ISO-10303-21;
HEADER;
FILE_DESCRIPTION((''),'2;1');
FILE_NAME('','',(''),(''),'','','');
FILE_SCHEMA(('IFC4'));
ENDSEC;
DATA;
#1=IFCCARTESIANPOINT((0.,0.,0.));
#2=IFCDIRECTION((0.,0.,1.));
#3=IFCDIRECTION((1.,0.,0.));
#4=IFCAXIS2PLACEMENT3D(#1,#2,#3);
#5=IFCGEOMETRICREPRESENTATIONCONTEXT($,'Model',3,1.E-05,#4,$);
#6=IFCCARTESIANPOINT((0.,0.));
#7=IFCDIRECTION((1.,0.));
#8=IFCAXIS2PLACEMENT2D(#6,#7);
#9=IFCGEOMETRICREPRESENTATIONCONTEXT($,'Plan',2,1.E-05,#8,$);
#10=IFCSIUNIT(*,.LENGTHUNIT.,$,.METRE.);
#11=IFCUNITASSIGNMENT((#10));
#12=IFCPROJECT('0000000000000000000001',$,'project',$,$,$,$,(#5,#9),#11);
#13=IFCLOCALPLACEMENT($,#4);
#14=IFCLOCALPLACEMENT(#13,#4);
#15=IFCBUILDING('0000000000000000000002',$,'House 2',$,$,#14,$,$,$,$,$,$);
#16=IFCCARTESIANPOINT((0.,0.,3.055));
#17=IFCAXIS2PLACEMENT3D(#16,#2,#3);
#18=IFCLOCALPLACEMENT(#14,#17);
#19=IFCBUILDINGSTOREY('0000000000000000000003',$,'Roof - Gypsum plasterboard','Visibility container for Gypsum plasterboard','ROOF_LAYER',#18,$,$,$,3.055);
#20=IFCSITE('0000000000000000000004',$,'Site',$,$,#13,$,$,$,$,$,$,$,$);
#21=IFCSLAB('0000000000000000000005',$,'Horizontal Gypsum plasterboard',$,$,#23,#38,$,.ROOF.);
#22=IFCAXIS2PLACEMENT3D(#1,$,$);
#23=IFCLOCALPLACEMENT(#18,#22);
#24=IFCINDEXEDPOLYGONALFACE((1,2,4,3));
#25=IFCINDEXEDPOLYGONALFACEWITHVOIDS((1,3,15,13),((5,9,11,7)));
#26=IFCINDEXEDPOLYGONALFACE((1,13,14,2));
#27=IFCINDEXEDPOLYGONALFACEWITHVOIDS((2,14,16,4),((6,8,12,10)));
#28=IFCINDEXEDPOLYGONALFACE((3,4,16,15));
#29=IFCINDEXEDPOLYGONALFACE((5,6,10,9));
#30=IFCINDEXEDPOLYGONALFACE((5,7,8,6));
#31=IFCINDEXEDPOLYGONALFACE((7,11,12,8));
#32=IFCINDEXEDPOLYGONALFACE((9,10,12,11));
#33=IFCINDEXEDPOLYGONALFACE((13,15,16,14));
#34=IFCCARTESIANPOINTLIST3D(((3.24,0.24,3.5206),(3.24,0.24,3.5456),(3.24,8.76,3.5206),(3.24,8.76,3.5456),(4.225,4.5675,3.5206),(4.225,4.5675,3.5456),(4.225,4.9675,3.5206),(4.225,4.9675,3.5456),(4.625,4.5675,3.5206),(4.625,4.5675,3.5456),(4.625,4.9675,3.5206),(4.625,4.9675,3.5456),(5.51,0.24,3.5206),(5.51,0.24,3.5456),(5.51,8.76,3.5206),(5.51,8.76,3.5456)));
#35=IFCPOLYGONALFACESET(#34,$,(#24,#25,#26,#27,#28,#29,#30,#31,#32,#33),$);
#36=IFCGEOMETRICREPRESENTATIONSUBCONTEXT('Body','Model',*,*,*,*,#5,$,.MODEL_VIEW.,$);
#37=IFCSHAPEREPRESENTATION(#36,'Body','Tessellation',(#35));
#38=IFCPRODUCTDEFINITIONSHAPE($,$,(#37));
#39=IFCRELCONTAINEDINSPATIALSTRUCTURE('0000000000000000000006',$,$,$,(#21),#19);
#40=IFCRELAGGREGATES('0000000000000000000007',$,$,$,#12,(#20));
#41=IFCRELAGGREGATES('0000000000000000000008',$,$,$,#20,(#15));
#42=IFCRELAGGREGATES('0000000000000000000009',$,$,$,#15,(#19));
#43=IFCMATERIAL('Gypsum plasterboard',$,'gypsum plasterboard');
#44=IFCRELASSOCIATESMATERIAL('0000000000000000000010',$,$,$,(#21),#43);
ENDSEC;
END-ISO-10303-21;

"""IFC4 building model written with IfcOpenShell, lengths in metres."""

from ifc_helpers import new_model, si_unit, frame, origin_with_axes, origin_2d_with_axis, place, context, subcontext, project, spatial, indexed_curve, outline, extrude, material, element, save


model = new_model("IFC4")

# Units and contexts
model_context = context("Model", 3, precision=1e-05, world=origin_with_axes())
plan_context = context("Plan", 2, precision=1e-05, world=origin_2d_with_axis())
body_context = subcontext(model_context, "Body", "Model", "MODEL_VIEW")
ifc_project = project(units=[si_unit("LENGTHUNIT", "METRE")], contexts=[model_context, plan_context])

# Site, building, storey
site_placement = place(None, origin_with_axes())
site = spatial("IfcSite", under=ifc_project, at=site_placement, Name="Site")
building_placement = place(site_placement, origin_with_axes())
building = spatial("IfcBuilding", under=site, at=building_placement, Name="House 2")
storey_placement = place(building_placement, frame((0.0, 0.0, 3.055), z_axis=(0.0, 0.0, 1.0), x_axis=(1.0, 0.0, 0.0)))
storey = spatial("IfcBuildingStorey", under=building, at=storey_placement, Name="Roof - Gypsum plasterboard", Description="Visibility container for Gypsum plasterboard", ObjectType="ROOF_LAYER", Elevation=3.055)

# Slab, opening
ifc_material = material(Name="Gypsum plasterboard", Category="gypsum plasterboard")
slab_1_placement = place(storey_placement, frame((0.0, 0.0, 3.5206), z_axis=(0.0, 0.0, 1.0), x_axis=(1.0, 0.0, 0.0)))
slab_1 = element("IfcSlab", 1, at=slab_1_placement, inside=storey, material=ifc_material, Name="Horizontal Gypsum plasterboard", PredefinedType="ROOF", context=body_context, shape_type="SweptSolid", body=[
    extrude(outline(indexed_curve([(3.24, 0.24), (5.51, 0.24), (5.51, 8.76), (3.24, 8.76)])), None, (0.0, 0.0, 1.0), 0.025),
])
opening_1_placement = place(slab_1_placement, frame((0.0, 0.0, -0.05), z_axis=(0.0, 0.0, 1.0), x_axis=(1.0, 0.0, 0.0)))
element("IfcOpeningElement", 2, at=opening_1_placement, cuts=slab_1, ObjectType="ROOF_OPENING", PredefinedType="OPENING", context=body_context, shape_type="SweptSolid", body=[
    extrude(outline(indexed_curve([(4.225, 4.5675), (4.625, 4.5675), (4.625, 4.9675), (4.225, 4.9675)])), None, (0.0, 0.0, 1.0), 0.125),
])

save(model, "model.ifc")
